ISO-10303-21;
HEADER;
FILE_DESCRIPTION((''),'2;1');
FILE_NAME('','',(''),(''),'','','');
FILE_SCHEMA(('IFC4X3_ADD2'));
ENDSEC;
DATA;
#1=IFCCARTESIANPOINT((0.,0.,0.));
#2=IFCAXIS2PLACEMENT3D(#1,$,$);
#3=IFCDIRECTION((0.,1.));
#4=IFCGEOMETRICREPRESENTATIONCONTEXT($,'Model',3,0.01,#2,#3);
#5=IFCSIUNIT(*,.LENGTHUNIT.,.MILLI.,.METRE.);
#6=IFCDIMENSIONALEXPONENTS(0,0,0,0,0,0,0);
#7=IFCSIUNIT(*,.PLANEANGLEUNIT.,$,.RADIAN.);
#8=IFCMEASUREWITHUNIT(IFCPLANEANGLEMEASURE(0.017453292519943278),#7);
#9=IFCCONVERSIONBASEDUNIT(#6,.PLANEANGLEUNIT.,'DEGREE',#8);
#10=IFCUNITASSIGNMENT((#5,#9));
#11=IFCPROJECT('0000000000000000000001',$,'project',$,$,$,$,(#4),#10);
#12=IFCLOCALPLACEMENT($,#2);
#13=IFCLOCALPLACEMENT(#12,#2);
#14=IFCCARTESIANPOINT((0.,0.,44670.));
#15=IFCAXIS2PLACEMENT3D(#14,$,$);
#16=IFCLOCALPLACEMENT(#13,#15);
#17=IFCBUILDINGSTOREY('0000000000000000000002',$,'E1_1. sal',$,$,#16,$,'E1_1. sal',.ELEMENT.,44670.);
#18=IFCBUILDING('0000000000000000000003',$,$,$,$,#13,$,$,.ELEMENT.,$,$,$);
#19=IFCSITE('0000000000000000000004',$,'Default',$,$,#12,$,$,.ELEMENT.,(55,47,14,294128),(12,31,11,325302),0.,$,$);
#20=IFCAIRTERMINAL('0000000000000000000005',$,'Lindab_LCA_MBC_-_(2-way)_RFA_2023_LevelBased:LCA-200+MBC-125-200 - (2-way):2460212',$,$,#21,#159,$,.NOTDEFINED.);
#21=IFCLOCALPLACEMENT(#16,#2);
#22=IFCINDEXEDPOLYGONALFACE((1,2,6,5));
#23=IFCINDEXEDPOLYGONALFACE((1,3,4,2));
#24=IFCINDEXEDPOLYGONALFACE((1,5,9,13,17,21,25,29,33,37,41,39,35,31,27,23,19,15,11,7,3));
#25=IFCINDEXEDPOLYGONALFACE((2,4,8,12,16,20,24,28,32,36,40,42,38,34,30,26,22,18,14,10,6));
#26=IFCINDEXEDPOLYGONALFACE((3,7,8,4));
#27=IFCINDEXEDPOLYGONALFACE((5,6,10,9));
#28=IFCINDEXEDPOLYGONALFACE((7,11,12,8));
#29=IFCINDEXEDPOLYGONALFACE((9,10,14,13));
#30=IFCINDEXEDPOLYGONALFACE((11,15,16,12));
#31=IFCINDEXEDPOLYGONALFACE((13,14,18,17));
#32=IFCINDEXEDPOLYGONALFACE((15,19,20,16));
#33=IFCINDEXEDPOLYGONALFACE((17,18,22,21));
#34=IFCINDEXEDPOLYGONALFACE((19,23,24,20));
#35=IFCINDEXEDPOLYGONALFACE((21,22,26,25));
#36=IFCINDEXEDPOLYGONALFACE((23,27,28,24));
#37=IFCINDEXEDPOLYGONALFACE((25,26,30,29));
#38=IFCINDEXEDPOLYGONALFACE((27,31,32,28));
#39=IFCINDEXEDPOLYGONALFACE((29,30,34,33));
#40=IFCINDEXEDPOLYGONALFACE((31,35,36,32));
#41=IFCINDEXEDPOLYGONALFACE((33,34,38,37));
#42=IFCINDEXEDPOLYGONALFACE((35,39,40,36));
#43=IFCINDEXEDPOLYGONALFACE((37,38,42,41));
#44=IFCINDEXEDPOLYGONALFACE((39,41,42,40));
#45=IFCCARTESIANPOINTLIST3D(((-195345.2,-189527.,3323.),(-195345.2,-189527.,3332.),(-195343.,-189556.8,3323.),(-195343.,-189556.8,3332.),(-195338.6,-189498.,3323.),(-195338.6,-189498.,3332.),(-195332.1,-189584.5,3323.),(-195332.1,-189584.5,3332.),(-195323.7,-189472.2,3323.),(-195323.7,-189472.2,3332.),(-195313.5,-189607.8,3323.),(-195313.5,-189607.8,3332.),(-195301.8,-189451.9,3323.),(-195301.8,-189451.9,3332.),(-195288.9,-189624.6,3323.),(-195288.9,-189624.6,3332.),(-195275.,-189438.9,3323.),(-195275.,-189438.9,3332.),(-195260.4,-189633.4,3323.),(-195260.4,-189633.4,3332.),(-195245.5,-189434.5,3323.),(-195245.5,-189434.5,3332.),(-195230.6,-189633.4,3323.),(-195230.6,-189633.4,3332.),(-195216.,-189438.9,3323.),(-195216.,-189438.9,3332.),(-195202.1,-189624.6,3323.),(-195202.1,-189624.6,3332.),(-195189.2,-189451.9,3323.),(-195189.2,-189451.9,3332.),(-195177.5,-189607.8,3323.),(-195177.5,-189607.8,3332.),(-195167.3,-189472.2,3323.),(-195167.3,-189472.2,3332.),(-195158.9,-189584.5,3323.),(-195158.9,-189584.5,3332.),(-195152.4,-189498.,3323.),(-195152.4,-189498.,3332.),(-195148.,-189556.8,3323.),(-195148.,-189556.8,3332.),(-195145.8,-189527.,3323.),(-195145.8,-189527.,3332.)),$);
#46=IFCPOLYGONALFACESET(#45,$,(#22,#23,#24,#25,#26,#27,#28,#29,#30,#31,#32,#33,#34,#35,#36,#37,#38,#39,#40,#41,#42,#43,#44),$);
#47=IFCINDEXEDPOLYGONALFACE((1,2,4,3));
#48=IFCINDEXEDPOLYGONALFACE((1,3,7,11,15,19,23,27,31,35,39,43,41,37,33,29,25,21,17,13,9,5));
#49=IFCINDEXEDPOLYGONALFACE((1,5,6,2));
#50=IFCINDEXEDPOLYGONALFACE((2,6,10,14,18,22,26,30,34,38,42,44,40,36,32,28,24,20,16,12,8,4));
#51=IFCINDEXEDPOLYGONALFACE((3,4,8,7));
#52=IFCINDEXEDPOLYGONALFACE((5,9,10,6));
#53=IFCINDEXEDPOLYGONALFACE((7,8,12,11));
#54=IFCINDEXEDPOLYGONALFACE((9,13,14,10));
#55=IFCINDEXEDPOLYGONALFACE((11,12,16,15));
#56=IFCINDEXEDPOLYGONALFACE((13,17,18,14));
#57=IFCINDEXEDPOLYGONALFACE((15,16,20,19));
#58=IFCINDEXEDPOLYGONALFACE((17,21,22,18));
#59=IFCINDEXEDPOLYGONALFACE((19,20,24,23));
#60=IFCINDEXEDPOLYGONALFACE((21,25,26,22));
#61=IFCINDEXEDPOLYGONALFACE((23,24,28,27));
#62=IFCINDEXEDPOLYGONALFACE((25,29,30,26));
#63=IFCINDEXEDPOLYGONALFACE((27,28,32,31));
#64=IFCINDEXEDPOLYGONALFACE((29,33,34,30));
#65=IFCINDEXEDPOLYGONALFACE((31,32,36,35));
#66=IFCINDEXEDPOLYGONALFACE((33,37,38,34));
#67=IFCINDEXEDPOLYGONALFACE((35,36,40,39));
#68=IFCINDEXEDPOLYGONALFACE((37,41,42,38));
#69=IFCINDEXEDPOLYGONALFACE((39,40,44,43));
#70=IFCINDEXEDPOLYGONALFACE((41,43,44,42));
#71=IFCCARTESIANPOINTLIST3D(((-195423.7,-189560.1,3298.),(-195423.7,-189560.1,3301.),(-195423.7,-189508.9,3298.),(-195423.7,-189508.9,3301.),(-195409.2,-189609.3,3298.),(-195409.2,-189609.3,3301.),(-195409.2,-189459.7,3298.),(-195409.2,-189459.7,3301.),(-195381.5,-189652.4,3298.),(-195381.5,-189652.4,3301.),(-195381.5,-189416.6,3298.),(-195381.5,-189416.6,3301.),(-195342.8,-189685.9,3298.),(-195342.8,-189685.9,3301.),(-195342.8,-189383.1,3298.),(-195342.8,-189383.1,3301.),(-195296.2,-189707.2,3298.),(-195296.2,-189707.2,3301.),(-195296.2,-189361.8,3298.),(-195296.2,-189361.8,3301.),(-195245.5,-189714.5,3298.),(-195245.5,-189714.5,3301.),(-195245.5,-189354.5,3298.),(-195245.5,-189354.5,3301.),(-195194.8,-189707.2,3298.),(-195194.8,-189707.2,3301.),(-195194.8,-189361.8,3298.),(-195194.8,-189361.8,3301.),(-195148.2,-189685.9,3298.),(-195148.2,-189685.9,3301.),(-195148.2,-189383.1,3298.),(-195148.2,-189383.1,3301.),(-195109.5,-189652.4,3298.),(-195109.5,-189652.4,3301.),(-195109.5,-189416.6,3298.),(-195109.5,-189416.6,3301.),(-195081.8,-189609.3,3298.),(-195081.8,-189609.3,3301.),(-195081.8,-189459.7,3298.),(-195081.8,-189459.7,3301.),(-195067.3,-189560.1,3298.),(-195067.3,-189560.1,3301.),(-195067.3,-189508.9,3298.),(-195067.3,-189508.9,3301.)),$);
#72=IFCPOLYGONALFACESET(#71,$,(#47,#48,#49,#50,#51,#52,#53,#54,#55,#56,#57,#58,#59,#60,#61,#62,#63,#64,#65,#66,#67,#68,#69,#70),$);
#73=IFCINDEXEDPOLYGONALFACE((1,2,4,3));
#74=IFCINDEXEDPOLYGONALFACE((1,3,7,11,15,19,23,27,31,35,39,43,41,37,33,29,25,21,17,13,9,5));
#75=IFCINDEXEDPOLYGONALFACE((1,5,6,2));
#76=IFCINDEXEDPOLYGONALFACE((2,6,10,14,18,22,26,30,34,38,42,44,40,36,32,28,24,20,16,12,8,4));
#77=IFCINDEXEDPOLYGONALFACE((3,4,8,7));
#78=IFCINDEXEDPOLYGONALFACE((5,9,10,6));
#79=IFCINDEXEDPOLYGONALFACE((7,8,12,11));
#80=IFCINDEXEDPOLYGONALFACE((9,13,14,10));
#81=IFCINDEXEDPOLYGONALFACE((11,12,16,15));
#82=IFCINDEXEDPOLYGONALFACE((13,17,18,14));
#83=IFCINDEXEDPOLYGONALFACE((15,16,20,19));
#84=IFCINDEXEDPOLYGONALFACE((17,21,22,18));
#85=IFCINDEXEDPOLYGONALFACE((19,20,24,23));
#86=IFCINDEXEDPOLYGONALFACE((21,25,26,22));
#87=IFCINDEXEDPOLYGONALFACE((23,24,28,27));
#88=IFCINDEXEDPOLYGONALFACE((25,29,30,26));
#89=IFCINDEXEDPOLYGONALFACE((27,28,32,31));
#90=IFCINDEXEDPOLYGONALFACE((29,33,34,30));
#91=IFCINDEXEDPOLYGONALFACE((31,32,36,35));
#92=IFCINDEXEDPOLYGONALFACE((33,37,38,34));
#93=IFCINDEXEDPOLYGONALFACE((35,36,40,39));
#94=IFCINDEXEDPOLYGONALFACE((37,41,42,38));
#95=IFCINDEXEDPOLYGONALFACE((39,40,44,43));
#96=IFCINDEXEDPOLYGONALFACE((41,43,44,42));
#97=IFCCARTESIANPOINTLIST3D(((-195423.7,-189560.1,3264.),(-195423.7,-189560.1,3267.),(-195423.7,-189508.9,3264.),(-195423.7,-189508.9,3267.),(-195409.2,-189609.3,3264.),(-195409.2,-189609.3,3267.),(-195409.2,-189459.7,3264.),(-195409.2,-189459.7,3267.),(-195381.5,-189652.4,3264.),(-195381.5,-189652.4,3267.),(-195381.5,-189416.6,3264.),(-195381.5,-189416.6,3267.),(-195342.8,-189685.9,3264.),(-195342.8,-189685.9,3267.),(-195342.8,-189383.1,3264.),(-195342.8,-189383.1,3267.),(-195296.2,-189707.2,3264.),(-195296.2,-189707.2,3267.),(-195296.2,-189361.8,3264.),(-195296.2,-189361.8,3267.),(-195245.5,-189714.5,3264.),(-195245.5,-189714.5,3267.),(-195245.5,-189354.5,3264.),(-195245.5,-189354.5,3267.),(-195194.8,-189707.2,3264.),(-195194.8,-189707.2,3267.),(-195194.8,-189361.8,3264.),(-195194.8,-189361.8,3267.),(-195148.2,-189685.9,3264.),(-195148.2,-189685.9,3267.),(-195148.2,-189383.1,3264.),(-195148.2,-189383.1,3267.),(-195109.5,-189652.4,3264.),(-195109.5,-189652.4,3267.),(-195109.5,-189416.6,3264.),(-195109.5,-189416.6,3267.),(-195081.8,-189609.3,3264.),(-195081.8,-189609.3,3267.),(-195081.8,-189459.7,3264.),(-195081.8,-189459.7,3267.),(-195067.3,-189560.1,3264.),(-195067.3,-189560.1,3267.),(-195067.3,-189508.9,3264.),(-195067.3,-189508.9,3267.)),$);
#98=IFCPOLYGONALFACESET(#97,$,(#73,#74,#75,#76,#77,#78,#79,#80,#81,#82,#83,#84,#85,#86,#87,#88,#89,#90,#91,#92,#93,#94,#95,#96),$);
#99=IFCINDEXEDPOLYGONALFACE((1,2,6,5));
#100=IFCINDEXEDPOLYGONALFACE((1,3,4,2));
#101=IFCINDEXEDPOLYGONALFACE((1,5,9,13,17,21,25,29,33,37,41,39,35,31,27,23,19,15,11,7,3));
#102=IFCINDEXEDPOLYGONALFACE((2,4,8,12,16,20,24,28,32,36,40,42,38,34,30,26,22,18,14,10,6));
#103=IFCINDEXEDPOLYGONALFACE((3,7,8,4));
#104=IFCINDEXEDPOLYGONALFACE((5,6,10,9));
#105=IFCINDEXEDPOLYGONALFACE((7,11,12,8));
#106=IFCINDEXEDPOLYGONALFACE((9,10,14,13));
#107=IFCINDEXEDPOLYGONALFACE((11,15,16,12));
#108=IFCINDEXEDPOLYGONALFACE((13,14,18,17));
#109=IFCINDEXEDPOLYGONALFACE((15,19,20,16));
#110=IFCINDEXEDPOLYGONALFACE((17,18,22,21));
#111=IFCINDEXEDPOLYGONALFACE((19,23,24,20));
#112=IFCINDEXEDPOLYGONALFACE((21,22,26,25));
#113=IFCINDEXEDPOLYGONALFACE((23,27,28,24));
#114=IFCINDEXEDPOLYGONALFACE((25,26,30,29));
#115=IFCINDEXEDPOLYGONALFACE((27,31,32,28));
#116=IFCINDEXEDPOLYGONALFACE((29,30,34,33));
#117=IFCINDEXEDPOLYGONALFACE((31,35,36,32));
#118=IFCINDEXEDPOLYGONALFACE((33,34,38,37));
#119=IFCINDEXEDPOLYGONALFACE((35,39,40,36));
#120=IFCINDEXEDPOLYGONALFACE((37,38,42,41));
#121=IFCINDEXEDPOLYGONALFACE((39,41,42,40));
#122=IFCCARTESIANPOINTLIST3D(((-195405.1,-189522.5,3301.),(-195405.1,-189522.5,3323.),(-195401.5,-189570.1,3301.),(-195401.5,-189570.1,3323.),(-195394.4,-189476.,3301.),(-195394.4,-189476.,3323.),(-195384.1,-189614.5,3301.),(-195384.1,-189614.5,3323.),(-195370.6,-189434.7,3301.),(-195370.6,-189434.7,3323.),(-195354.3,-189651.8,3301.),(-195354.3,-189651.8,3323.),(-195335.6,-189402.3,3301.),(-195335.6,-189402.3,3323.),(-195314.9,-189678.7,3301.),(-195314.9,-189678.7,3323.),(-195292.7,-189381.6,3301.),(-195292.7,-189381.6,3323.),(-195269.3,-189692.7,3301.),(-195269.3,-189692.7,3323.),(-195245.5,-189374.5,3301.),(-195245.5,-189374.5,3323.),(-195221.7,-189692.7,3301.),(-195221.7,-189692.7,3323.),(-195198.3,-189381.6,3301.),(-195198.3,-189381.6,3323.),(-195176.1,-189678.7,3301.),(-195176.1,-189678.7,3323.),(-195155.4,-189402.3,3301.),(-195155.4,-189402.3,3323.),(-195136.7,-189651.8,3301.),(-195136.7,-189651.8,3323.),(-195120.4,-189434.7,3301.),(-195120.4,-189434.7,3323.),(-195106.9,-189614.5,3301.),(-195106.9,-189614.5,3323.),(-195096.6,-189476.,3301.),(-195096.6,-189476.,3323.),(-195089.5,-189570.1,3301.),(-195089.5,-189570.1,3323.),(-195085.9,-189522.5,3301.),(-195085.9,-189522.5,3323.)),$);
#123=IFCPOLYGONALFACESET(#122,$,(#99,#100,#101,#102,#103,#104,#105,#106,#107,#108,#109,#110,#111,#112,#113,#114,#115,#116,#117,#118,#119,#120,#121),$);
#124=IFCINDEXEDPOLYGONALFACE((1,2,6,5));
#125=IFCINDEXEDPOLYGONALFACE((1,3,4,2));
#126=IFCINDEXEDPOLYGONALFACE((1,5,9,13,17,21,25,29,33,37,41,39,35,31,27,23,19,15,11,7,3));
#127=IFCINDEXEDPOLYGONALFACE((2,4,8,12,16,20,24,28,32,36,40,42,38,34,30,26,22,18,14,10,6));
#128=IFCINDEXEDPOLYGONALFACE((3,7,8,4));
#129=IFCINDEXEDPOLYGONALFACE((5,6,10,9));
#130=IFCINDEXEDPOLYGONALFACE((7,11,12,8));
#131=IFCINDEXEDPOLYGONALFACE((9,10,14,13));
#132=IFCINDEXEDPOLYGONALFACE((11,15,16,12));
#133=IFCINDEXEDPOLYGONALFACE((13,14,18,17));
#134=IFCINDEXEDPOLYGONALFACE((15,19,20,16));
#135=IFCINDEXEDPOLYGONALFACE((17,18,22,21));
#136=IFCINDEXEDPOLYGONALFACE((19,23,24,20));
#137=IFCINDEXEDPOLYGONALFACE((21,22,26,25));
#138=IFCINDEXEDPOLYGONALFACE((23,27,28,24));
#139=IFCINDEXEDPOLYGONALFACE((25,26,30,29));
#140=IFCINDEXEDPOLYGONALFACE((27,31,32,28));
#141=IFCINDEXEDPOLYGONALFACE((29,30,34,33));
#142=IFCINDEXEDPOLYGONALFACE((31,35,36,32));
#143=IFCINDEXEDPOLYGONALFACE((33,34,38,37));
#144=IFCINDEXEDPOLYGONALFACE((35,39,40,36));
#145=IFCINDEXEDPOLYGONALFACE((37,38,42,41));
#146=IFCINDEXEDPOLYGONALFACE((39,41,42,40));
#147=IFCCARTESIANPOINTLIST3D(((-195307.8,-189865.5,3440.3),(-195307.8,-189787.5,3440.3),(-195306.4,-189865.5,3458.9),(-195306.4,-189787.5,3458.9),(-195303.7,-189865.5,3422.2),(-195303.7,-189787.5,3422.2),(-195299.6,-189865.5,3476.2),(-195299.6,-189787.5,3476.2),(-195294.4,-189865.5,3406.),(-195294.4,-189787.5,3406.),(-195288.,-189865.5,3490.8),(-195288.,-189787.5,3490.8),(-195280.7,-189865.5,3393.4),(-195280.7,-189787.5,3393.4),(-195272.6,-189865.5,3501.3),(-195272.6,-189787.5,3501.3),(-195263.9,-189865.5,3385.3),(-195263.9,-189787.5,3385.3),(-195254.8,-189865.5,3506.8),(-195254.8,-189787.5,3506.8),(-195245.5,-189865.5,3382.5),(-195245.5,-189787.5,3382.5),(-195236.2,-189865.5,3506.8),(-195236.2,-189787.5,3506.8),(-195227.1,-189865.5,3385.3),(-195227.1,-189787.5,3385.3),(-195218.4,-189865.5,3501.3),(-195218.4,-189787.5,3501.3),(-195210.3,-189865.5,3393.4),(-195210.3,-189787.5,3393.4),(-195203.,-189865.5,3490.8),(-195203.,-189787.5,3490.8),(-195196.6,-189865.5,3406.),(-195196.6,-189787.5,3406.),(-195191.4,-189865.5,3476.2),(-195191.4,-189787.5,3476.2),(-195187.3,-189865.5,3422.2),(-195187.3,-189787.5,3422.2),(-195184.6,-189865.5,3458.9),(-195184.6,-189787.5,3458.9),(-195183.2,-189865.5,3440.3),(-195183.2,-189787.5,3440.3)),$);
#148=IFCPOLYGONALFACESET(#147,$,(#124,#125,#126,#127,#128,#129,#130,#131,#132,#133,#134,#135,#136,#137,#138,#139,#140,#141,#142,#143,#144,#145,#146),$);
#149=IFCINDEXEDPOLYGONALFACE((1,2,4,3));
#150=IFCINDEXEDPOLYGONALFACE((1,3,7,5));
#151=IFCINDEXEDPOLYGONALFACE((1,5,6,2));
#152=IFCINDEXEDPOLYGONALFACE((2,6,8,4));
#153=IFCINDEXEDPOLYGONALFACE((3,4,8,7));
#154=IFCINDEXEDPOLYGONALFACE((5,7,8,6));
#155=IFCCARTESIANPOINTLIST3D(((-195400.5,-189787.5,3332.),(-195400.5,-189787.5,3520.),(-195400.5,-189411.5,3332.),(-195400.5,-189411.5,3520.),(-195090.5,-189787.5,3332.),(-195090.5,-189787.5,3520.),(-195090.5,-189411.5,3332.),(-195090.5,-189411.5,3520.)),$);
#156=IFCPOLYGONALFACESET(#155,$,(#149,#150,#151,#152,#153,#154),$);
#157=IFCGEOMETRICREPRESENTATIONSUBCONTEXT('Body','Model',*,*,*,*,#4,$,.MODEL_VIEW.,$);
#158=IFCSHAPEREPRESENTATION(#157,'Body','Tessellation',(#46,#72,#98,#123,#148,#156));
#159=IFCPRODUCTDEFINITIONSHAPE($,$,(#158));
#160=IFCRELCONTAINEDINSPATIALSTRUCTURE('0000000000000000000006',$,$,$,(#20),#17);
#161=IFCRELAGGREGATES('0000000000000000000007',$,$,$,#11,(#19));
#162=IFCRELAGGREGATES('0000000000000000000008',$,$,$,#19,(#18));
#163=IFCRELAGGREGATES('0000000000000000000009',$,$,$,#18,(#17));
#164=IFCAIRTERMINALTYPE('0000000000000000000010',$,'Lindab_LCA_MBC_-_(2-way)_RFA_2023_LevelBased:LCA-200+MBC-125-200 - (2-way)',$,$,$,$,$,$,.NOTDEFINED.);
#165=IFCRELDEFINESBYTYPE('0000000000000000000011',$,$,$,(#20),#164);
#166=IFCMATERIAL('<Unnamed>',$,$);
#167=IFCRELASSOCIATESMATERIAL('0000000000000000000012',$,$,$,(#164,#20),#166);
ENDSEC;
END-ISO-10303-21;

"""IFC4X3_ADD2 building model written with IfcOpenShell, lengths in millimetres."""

from ifc_helpers import new_model, entity, si_unit, converted_unit, direction, frame, frame_2d, origin, origin_2d_with_axis, place, context, subcontext, project, spatial, rectangle, circle, extrude, source, transform, mapped, material, type_object, type_shapes, element, save


model = new_model("IFC4X3_ADD2")

# Units and contexts
model_context = context("Model", 3, precision=0.01, world=origin(), true_north=direction((0.0, 1.0)))
body_context = subcontext(model_context, "Body", "Model", "MODEL_VIEW")
ifc_project = project(units=[si_unit("LENGTHUNIT", "METRE", prefix="MILLI"), converted_unit("PLANEANGLEUNIT", "DEGREE", entity("IfcPlaneAngleMeasure", 0.017453292519943278), si_unit("PLANEANGLEUNIT", "RADIAN"), dimensions=[0, 0, 0, 0, 0, 0, 0])], contexts=[model_context])

# Site, building, storey
site_placement = place(None, origin())
site = spatial("IfcSite", under=ifc_project, at=site_placement, Name="Default", CompositionType="ELEMENT", RefLatitude=(55, 47, 14, 294128), RefLongitude=(12, 31, 11, 325302), RefElevation=0.0)
building_placement = place(site_placement, origin())
building = spatial("IfcBuilding", under=site, at=building_placement, CompositionType="ELEMENT")
storey_placement = place(building_placement, frame((0.0, 0.0, 44670.0)))
storey = spatial("IfcBuildingStorey", under=building, at=storey_placement, Name="E1_1. sal", LongName="E1_1. sal", CompositionType="ELEMENT", Elevation=44670.0)

# Air terminal
ifc_material_1 = material(Name="<Unnamed>")
air_terminal_type = type_object("IfcAirTerminalType", Name="Lindab_LCA_MBC_-_(2-way)_RFA_2023_LevelBased:LCA-200+MBC-125-200 - (2-way)", PredefinedType="NOTDEFINED", material=ifc_material_1)
shared_shape_1 = source(origin(), body_context, "Body", "SweptSolid", [
    extrude(circle(Radius=100.0, at=frame_2d((0.0, 0.0), x_axis=(1.0, 0.0))), frame((0.0, 0.0, 22.0)), (0.0, 0.0, 1.0), 9.0),
    extrude(circle(Radius=180.0, at=frame_2d((0.0, 0.0), x_axis=(1.0, 0.0))), frame((0.0, 0.0, -3.0)), (0.0, 0.0, 1.0), 3.0),
    extrude(circle(Radius=180.0, at=frame_2d((0.0, 0.0), x_axis=(1.0, 0.0))), frame((0.0, 0.0, -37.0)), (0.0, 0.0, 1.0), 3.0),
    extrude(circle(Radius=160.0, at=frame_2d((0.0, 0.0), x_axis=(1.0, 0.0))), origin(), (0.0, 0.0, 1.0), 22.0),
    extrude(circle(Radius=62.5, at=frame_2d((0.0, 0.0), x_axis=(1.0, 0.0))), frame((-331.0, 0.0, 144.0), z_axis=(1.0, 0.0, 0.0), x_axis=(0.0, 0.0, -1.0)), (0.0, 0.0, 1.0), 78.0),
    extrude(rectangle(XDim=310.0, YDim=376.0, at=origin_2d_with_axis()), frame((-65.0, 0.0, 31.0), z_axis=(0.0, 0.0, 1.0), x_axis=(0.0, -1.0, 0.0)), (0.0, 0.0, 1.0), 188.0),
])
type_shapes(air_terminal_type, [shared_shape_1])
for number, where, z_axis, x_axis, name in (
    (1, (-195245.5, -189534.5, 3301.0), (0.0, 0.0, 1.0), (0.0, 1.0, 0.0), "Lindab_LCA_MBC_-_(2-way)_RFA_2023_LevelBased:LCA-200+MBC-125-200 - (2-way):2460212"),
):
    element("IfcAirTerminal", number, at=place(storey_placement, frame(where, z_axis=z_axis, x_axis=x_axis)), inside=storey, type_object=air_terminal_type, material=ifc_material_1, Name=name, PredefinedType="NOTDEFINED", context=body_context, shape_type="MappedRepresentation", body=[
        mapped(shared_shape_1, transform((0.0, 0.0, 0.0), scale=1.0)),
    ])

save(model, "model.ifc")
